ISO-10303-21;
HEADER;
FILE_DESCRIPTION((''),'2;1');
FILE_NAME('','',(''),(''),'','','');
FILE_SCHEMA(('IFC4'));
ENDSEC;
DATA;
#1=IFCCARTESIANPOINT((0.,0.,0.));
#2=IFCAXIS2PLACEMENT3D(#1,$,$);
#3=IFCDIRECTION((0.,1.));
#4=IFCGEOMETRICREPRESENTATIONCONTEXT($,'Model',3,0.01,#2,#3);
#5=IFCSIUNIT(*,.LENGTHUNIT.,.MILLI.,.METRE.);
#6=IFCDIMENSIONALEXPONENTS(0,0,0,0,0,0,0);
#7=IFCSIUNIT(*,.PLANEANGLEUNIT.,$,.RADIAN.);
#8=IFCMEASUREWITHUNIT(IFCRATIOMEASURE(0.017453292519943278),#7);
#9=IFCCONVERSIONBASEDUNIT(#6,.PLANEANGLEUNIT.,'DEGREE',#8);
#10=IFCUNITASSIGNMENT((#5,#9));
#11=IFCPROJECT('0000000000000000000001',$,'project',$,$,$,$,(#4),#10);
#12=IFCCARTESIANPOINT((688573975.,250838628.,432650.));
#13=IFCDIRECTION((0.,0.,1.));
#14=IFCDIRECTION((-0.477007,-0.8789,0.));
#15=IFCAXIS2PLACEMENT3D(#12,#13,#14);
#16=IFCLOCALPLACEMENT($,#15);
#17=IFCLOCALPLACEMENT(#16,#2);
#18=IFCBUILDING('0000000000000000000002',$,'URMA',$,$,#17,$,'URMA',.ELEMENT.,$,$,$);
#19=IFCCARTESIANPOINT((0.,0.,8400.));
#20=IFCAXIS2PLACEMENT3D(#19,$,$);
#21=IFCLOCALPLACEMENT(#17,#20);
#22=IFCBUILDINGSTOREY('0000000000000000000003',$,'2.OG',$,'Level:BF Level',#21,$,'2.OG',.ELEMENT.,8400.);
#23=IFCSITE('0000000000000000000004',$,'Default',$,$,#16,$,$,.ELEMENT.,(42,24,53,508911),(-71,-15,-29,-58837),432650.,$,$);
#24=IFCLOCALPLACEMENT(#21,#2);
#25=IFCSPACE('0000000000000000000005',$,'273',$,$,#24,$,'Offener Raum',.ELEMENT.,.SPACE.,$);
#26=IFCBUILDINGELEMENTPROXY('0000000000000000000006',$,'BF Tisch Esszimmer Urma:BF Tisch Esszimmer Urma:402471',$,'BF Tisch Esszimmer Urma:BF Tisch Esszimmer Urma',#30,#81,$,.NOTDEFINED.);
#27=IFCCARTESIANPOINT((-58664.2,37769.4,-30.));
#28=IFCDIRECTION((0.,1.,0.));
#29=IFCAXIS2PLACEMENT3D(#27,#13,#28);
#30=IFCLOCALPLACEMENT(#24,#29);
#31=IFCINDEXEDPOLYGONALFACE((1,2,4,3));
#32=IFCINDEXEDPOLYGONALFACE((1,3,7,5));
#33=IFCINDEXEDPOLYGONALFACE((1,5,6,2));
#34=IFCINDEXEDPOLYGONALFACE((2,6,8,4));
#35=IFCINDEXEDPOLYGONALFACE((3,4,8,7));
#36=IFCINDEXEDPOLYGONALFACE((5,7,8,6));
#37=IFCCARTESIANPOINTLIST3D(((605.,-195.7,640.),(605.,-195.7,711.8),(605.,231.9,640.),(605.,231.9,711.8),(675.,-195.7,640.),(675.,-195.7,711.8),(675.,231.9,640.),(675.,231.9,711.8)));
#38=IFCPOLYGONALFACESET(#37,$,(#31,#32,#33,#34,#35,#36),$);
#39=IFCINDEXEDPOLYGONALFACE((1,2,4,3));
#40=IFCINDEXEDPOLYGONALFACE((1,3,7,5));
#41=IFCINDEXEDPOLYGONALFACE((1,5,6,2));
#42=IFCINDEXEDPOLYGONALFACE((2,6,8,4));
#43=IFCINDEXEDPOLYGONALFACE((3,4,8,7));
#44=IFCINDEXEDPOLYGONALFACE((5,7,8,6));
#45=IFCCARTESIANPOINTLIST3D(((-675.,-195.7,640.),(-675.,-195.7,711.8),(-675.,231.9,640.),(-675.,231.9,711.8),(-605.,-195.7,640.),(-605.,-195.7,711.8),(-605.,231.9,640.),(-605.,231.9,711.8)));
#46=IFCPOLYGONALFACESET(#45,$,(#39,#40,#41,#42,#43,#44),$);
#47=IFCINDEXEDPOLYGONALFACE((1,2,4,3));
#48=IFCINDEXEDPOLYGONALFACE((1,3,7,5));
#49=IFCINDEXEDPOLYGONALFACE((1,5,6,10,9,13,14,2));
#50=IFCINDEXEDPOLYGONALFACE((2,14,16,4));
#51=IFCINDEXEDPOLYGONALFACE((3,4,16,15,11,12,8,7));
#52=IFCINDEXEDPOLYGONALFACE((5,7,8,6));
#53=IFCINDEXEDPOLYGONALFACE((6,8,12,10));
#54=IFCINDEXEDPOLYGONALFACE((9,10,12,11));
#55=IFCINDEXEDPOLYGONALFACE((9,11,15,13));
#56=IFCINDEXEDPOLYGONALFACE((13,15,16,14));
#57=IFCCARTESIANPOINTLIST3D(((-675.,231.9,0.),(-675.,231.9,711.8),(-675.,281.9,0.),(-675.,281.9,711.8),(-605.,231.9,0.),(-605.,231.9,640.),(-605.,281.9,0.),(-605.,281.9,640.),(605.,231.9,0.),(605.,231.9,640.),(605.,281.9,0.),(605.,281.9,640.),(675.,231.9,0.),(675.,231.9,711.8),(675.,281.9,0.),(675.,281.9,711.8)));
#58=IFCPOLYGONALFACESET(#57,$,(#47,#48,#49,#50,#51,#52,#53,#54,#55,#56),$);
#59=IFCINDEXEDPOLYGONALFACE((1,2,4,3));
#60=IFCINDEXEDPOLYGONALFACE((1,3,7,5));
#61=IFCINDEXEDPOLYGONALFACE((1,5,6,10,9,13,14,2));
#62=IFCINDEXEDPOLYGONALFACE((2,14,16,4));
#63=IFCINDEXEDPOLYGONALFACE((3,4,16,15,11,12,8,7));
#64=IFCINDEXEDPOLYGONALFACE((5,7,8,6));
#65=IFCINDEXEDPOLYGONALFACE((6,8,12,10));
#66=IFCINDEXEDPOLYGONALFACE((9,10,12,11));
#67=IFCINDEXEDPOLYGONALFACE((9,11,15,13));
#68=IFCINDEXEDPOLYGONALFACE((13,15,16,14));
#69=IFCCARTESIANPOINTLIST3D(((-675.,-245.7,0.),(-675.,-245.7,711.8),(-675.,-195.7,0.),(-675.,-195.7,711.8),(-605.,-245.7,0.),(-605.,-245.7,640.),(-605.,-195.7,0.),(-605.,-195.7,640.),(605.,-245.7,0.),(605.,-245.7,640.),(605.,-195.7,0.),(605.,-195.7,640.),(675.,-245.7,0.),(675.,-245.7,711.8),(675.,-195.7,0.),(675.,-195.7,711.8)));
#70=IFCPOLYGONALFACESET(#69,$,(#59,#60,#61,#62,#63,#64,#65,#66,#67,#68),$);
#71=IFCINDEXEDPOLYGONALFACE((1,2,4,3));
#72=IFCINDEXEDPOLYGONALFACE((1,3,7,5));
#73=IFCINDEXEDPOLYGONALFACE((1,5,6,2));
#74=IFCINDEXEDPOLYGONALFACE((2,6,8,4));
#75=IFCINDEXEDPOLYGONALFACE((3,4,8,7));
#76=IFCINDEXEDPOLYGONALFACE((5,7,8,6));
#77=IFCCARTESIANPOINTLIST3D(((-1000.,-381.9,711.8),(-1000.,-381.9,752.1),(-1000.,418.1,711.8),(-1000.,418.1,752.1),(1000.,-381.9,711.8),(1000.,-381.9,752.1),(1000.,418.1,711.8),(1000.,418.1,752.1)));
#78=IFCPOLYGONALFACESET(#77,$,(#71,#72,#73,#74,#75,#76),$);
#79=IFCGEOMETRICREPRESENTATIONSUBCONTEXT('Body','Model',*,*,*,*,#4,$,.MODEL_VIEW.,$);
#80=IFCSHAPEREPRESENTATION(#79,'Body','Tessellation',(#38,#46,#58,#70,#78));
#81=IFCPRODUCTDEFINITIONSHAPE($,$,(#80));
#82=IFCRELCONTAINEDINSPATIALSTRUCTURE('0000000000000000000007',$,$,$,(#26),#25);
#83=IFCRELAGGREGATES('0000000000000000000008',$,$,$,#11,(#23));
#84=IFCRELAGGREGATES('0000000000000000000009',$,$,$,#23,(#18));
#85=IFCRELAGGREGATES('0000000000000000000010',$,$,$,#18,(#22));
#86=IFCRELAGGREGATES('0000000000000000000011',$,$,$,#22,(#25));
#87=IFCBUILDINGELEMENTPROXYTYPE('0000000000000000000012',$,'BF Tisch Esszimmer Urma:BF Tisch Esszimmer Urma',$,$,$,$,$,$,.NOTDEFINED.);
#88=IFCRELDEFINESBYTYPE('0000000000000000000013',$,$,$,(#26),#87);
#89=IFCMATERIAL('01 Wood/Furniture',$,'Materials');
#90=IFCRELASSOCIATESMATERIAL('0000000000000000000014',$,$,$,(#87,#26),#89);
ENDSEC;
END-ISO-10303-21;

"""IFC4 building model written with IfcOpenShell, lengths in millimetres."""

from ifc_helpers import new_model, entity, si_unit, converted_unit, direction, frame, origin, place, context, subcontext, project, spatial, indexed_curve, outline, extrude, source, transform, mapped, material, type_object, type_shapes, element, save


model = new_model("IFC4")

# Units and contexts
model_context = context("Model", 3, precision=0.01, world=origin(), true_north=direction((0.0, 1.0)))
body_context = subcontext(model_context, "Body", "Model", "MODEL_VIEW")
ifc_project = project(units=[si_unit("LENGTHUNIT", "METRE", prefix="MILLI"), converted_unit("PLANEANGLEUNIT", "DEGREE", entity("IfcRatioMeasure", 0.017453292519943278), si_unit("PLANEANGLEUNIT", "RADIAN"), dimensions=[0, 0, 0, 0, 0, 0, 0])], contexts=[model_context])

# Site, building, storey
site_placement = place(None, frame((688573975.0, 250838628.0, 432650.0), z_axis=(0.0, 0.0, 1.0), x_axis=(-0.477007, -0.8789, 0.0)))
site = spatial("IfcSite", under=ifc_project, at=site_placement, Name="Default", CompositionType="ELEMENT", RefLatitude=(42, 24, 53, 508911), RefLongitude=(-71, -15, -29, -58837), RefElevation=432650.0)
building_placement = place(site_placement, origin())
building = spatial("IfcBuilding", under=site, at=building_placement, Name="URMA", LongName="URMA", CompositionType="ELEMENT")
storey_placement = place(building_placement, frame((0.0, 0.0, 8400.0)))
storey = spatial("IfcBuildingStorey", under=building, at=storey_placement, Name="2.OG", ObjectType="Level:BF Level", LongName="2.OG", CompositionType="ELEMENT", Elevation=8400.0)

# Shared definitions
space_1_placement = place(storey_placement, origin())
space_1 = spatial("IfcSpace", under=storey, at=space_1_placement, Name="273", LongName="Offener Raum", CompositionType="ELEMENT", PredefinedType="SPACE")

# Building element proxy
ifc_material_1 = material(Name="01 Wood/Furniture", Category="Materials")
building_element_proxy_type_1 = type_object("IfcBuildingElementProxyType", Name="BF Tisch Esszimmer Urma:BF Tisch Esszimmer Urma", PredefinedType="NOTDEFINED", material=ifc_material_1)
shared_shape_1 = source(origin(), body_context, "Body", "SweptSolid", [
    extrude(outline(indexed_curve([(-35.0, -213.8), (35.0, -213.8), (35.0, 213.8), (-35.0, 213.8), (-35.0, -213.8)], self_intersect=False)), frame((640.0, 18.1, 640.0), z_axis=(0.0, 0.0, 1.0), x_axis=(-1.0, 0.0, 0.0)), (0.0, 0.0, 1.0), 71.8),
    extrude(outline(indexed_curve([(-35.0, -213.8), (35.0, -213.8), (35.0, 213.8), (-35.0, 213.8), (-35.0, -213.8)], self_intersect=False)), frame((-640.0, 18.1, 640.0), z_axis=(0.0, 0.0, 1.0), x_axis=(-1.0, 0.0, 0.0)), (0.0, 0.0, 1.0), 71.8),
    extrude(outline(indexed_curve([(-302.0, 605.0), (338.0, 605.0), (338.0, 675.0), (-373.9, 675.0), (-373.9, -675.0), (338.0, -675.0), (338.0, -605.0), (-302.0, -605.0), (-302.0, 605.0)], self_intersect=False)), frame((0.0, 231.9, 338.0), z_axis=(0.0, 1.0, 0.0), x_axis=(0.0, 0.0, -1.0)), (0.0, 0.0, 1.0), 50.0),
    extrude(outline(indexed_curve([(-302.0, 605.0), (338.0, 605.0), (338.0, 675.0), (-373.9, 675.0), (-373.9, -675.0), (338.0, -675.0), (338.0, -605.0), (-302.0, -605.0), (-302.0, 605.0)], self_intersect=False)), frame((0.0, -245.7, 338.0), z_axis=(0.0, 1.0, 0.0), x_axis=(0.0, 0.0, -1.0)), (0.0, 0.0, 1.0), 50.0),
    extrude(outline(indexed_curve([(-1000.0, -400.0), (1000.0, -400.0), (1000.0, 400.0), (-1000.0, 400.0), (-1000.0, -400.0)], self_intersect=False)), frame((0.0, 18.1, 711.8), z_axis=(0.0, 0.0, 1.0), x_axis=(-1.0, 0.0, 0.0)), (0.0, 0.0, 1.0), 40.3),
])
type_shapes(building_element_proxy_type_1, [shared_shape_1])
proxy_1_placement = place(space_1_placement, frame((-58664.2, 37769.4, -30.0), z_axis=(0.0, 0.0, 1.0), x_axis=(0.0, 1.0, 0.0)))
element("IfcBuildingElementProxy", 1, at=proxy_1_placement, inside=space_1, type_object=building_element_proxy_type_1, material=ifc_material_1, Name="BF Tisch Esszimmer Urma:BF Tisch Esszimmer Urma:402471", ObjectType="BF Tisch Esszimmer Urma:BF Tisch Esszimmer Urma", PredefinedType="NOTDEFINED", context=body_context, shape_type="MappedRepresentation", body=[
    mapped(shared_shape_1, transform((0.0, 0.0, 0.0), scale=1.0)),
])

save(model, "model.ifc")
